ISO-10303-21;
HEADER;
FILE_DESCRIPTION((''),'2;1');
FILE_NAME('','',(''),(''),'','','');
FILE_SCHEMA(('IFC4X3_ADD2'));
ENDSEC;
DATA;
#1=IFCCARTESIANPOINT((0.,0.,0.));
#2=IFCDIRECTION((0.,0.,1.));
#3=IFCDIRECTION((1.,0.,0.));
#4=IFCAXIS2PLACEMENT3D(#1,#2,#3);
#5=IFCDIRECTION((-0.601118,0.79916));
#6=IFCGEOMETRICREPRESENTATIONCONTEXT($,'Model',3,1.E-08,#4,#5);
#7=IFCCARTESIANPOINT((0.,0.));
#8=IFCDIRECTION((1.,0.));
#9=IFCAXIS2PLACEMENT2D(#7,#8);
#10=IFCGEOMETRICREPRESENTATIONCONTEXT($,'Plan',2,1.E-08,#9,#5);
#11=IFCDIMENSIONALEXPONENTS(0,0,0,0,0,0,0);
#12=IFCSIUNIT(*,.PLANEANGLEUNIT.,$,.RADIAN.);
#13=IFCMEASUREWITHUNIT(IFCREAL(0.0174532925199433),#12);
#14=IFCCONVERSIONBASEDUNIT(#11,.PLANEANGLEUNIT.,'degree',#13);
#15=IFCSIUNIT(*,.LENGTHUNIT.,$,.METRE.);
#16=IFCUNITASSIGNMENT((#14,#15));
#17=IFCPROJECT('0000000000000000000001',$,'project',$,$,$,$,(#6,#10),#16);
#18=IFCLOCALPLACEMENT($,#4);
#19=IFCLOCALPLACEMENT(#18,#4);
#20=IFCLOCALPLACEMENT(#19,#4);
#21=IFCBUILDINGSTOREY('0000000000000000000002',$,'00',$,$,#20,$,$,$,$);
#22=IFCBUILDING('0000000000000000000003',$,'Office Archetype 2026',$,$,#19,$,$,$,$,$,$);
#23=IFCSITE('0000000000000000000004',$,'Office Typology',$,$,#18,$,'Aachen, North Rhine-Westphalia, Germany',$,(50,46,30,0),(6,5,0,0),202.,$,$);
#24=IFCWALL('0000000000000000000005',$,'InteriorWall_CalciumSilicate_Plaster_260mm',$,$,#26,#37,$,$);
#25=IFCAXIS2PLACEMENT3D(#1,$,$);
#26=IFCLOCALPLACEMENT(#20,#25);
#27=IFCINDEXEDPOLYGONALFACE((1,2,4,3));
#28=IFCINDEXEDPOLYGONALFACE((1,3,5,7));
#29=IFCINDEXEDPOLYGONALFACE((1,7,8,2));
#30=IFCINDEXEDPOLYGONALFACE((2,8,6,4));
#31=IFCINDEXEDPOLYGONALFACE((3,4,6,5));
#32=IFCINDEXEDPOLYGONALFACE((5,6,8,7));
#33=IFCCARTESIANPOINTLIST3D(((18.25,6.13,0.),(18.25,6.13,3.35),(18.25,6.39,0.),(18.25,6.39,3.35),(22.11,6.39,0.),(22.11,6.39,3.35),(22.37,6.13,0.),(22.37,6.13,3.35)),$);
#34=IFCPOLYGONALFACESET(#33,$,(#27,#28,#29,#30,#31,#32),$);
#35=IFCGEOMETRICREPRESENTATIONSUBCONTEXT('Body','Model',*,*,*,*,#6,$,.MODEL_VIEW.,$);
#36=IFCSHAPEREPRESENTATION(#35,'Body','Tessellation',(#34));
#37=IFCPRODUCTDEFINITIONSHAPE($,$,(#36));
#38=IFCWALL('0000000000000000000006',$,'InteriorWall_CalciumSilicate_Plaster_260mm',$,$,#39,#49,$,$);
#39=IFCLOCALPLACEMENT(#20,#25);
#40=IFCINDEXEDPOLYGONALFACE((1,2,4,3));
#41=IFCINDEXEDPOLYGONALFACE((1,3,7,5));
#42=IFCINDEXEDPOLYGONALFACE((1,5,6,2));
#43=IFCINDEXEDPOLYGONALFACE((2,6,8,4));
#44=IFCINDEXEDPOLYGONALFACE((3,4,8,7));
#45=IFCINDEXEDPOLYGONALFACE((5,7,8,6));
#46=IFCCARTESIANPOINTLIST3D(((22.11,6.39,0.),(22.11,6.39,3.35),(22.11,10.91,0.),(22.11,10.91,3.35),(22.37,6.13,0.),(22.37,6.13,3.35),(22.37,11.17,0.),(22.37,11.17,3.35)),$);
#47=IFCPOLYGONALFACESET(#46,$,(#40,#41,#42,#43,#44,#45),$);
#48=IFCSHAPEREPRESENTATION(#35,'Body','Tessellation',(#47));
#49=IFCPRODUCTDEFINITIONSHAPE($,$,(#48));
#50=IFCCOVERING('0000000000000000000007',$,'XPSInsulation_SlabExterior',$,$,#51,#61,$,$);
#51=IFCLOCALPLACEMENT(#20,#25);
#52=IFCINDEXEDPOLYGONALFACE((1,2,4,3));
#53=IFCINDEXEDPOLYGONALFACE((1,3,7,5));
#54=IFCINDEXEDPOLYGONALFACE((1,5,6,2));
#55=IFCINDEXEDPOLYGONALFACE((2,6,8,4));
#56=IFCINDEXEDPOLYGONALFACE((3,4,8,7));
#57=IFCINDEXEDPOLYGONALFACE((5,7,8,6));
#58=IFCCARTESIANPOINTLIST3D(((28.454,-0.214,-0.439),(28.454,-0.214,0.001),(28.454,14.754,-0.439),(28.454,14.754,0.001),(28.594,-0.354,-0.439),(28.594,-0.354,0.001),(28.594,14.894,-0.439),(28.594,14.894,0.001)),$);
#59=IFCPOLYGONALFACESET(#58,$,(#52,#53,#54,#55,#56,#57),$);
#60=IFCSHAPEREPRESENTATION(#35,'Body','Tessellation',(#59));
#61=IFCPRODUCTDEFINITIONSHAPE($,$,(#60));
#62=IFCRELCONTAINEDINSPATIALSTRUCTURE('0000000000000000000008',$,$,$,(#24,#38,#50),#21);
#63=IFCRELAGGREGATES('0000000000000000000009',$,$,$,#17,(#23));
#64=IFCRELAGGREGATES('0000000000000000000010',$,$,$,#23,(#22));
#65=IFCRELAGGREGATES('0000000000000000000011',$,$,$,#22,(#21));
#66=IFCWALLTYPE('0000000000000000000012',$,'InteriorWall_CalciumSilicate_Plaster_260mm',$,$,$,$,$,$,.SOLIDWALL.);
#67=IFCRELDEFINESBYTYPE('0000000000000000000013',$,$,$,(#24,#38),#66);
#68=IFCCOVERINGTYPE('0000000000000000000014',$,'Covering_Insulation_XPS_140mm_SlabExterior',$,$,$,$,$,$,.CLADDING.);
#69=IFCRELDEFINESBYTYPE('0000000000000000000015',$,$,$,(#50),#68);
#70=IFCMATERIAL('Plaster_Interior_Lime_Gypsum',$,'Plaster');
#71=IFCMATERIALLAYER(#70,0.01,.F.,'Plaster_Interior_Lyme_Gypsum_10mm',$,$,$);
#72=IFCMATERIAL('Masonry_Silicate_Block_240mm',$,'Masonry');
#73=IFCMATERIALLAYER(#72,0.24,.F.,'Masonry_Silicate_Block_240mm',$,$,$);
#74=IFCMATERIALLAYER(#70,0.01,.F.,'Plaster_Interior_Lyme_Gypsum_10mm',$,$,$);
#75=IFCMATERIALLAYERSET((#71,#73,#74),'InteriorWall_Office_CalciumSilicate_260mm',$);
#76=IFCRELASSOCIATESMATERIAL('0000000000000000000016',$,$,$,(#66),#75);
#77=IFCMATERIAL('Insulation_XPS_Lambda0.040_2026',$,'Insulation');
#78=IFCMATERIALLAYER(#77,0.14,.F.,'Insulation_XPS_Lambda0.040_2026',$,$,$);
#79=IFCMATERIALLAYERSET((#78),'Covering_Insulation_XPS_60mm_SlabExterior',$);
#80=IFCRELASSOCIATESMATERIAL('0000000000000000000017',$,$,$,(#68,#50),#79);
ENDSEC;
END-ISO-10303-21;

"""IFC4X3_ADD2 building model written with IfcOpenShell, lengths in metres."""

from ifc_helpers import new_model, entity, si_unit, converted_unit, direction, frame, origin_with_axes, origin_2d_with_axis, place, context, subcontext, project, spatial, line, indexed_curve, outline, extrude, material, layer, layer_set, layer_usage, type_object, element, save


model = new_model("IFC4X3_ADD2")

# Units and contexts
model_context = context("Model", 3, precision=1e-08, world=origin_with_axes(), true_north=direction((-0.601118, 0.79916)))
plan_context = context("Plan", 2, precision=1e-08, world=origin_2d_with_axis(), true_north=direction((-0.601118, 0.79916)))
body_context = subcontext(model_context, "Body", "Model", "MODEL_VIEW")
ifc_project = project(units=[converted_unit("PLANEANGLEUNIT", "degree", entity("IfcReal", 0.0174532925199433), si_unit("PLANEANGLEUNIT", "RADIAN"), dimensions=[0, 0, 0, 0, 0, 0, 0]), si_unit("LENGTHUNIT", "METRE")], contexts=[model_context, plan_context])

# Site, building, storey
site_placement = place(None, origin_with_axes())
site = spatial("IfcSite", under=ifc_project, at=site_placement, Name="Office Typology", LongName="Aachen, North Rhine-Westphalia, Germany", RefLatitude=(50, 46, 30, 0), RefLongitude=(6, 5, 0, 0), RefElevation=202.0)
building_placement = place(site_placement, origin_with_axes())
building = spatial("IfcBuilding", under=site, at=building_placement, Name="Office Archetype 2026")
storey_placement = place(building_placement, origin_with_axes())
storey = spatial("IfcBuildingStorey", under=building, at=storey_placement, Name="00")

# Walls
ifc_material_1 = material(Name="Plaster_Interior_Lime_Gypsum", Category="Plaster")
ifc_layer_1 = layer(ifc_material_1, 0.01, ventilated=False, Name="Plaster_Interior_Lyme_Gypsum_10mm")
ifc_material_2 = material(Name="Masonry_Silicate_Block_240mm", Category="Masonry")
ifc_layer_2 = layer(ifc_material_2, 0.24, ventilated=False, Name="Masonry_Silicate_Block_240mm")
ifc_layer_3 = layer(ifc_material_1, 0.01, ventilated=False, Name="Plaster_Interior_Lyme_Gypsum_10mm")
ifc_layer_set_1 = layer_set([ifc_layer_1, ifc_layer_2, ifc_layer_3], Name="InteriorWall_Office_CalciumSilicate_260mm")
wall_type_1 = type_object("IfcWallType", Name="InteriorWall_CalciumSilicate_Plaster_260mm", PredefinedType="SOLIDWALL", material=ifc_layer_set_1)
wall_1_placement = place(storey_placement, frame((18.25, 6.13, 0.0), z_axis=(0.0, 0.0, 1.0), x_axis=(1.0, 0.0, 0.0)))
element("IfcWall", 1, at=wall_1_placement, inside=storey, type_object=wall_type_1, Name="InteriorWall_CalciumSilicate_Plaster_260mm", context=body_context, shape_type="SweptSolid", body=[
    extrude(outline(indexed_curve([(0.0, 0.0), (0.0, 0.26), (3.86, 0.26), (4.12, 0.0)], segments=[line(1, 2, 3, 4, 1)])), origin_with_axes(), (0.0, 0.0, 1.0), 3.35),
])
wall_2_placement = place(storey_placement, frame((22.37, 6.13, 0.0), z_axis=(0.0, 0.0, 1.0), x_axis=(0.0, 1.0, 0.0)))
element("IfcWall", 2, at=wall_2_placement, inside=storey, type_object=wall_type_1, Name="InteriorWall_CalciumSilicate_Plaster_260mm", context=body_context, shape_type="SweptSolid", body=[
    extrude(outline(indexed_curve([(0.0, 0.0), (0.26, 0.26), (4.78, 0.26), (5.04, 0.0)], segments=[line(1, 2, 3, 4, 1)])), origin_with_axes(), (0.0, 0.0, 1.0), 3.35),
])

# Covering
ifc_material_3 = material(Name="Insulation_XPS_Lambda0.040_2026", Category="Insulation")
ifc_layer_4 = layer(ifc_material_3, 0.14, ventilated=False, Name="Insulation_XPS_Lambda0.040_2026")
ifc_layer_set_2 = layer_set([ifc_layer_4], Name="Covering_Insulation_XPS_60mm_SlabExterior")
ifc_layer_usage_1 = layer_usage(ifc_layer_set_2, "AXIS2", "POSITIVE", 0.0)
covering_type = type_object("IfcCoveringType", Name="Covering_Insulation_XPS_140mm_SlabExterior", PredefinedType="CLADDING", material=ifc_layer_set_2)
covering_placement = place(storey_placement, frame((28.594, -0.354, -0.439), z_axis=(0.0, 0.0, 1.0), x_axis=(0.0, 1.0, 0.0)))
element("IfcCovering", 3, at=covering_placement, inside=storey, type_object=covering_type, material=ifc_layer_usage_1, Name="XPSInsulation_SlabExterior", context=body_context, shape_type="SweptSolid", body=[
    extrude(outline(indexed_curve([(0.0, 0.0), (0.14, 0.14), (15.108, 0.14), (15.248, 0.0)], segments=[line(1, 2, 3, 4, 1)])), origin_with_axes(), (0.0, 0.0, 1.0), 0.44),
])

save(model, "model.ifc")
